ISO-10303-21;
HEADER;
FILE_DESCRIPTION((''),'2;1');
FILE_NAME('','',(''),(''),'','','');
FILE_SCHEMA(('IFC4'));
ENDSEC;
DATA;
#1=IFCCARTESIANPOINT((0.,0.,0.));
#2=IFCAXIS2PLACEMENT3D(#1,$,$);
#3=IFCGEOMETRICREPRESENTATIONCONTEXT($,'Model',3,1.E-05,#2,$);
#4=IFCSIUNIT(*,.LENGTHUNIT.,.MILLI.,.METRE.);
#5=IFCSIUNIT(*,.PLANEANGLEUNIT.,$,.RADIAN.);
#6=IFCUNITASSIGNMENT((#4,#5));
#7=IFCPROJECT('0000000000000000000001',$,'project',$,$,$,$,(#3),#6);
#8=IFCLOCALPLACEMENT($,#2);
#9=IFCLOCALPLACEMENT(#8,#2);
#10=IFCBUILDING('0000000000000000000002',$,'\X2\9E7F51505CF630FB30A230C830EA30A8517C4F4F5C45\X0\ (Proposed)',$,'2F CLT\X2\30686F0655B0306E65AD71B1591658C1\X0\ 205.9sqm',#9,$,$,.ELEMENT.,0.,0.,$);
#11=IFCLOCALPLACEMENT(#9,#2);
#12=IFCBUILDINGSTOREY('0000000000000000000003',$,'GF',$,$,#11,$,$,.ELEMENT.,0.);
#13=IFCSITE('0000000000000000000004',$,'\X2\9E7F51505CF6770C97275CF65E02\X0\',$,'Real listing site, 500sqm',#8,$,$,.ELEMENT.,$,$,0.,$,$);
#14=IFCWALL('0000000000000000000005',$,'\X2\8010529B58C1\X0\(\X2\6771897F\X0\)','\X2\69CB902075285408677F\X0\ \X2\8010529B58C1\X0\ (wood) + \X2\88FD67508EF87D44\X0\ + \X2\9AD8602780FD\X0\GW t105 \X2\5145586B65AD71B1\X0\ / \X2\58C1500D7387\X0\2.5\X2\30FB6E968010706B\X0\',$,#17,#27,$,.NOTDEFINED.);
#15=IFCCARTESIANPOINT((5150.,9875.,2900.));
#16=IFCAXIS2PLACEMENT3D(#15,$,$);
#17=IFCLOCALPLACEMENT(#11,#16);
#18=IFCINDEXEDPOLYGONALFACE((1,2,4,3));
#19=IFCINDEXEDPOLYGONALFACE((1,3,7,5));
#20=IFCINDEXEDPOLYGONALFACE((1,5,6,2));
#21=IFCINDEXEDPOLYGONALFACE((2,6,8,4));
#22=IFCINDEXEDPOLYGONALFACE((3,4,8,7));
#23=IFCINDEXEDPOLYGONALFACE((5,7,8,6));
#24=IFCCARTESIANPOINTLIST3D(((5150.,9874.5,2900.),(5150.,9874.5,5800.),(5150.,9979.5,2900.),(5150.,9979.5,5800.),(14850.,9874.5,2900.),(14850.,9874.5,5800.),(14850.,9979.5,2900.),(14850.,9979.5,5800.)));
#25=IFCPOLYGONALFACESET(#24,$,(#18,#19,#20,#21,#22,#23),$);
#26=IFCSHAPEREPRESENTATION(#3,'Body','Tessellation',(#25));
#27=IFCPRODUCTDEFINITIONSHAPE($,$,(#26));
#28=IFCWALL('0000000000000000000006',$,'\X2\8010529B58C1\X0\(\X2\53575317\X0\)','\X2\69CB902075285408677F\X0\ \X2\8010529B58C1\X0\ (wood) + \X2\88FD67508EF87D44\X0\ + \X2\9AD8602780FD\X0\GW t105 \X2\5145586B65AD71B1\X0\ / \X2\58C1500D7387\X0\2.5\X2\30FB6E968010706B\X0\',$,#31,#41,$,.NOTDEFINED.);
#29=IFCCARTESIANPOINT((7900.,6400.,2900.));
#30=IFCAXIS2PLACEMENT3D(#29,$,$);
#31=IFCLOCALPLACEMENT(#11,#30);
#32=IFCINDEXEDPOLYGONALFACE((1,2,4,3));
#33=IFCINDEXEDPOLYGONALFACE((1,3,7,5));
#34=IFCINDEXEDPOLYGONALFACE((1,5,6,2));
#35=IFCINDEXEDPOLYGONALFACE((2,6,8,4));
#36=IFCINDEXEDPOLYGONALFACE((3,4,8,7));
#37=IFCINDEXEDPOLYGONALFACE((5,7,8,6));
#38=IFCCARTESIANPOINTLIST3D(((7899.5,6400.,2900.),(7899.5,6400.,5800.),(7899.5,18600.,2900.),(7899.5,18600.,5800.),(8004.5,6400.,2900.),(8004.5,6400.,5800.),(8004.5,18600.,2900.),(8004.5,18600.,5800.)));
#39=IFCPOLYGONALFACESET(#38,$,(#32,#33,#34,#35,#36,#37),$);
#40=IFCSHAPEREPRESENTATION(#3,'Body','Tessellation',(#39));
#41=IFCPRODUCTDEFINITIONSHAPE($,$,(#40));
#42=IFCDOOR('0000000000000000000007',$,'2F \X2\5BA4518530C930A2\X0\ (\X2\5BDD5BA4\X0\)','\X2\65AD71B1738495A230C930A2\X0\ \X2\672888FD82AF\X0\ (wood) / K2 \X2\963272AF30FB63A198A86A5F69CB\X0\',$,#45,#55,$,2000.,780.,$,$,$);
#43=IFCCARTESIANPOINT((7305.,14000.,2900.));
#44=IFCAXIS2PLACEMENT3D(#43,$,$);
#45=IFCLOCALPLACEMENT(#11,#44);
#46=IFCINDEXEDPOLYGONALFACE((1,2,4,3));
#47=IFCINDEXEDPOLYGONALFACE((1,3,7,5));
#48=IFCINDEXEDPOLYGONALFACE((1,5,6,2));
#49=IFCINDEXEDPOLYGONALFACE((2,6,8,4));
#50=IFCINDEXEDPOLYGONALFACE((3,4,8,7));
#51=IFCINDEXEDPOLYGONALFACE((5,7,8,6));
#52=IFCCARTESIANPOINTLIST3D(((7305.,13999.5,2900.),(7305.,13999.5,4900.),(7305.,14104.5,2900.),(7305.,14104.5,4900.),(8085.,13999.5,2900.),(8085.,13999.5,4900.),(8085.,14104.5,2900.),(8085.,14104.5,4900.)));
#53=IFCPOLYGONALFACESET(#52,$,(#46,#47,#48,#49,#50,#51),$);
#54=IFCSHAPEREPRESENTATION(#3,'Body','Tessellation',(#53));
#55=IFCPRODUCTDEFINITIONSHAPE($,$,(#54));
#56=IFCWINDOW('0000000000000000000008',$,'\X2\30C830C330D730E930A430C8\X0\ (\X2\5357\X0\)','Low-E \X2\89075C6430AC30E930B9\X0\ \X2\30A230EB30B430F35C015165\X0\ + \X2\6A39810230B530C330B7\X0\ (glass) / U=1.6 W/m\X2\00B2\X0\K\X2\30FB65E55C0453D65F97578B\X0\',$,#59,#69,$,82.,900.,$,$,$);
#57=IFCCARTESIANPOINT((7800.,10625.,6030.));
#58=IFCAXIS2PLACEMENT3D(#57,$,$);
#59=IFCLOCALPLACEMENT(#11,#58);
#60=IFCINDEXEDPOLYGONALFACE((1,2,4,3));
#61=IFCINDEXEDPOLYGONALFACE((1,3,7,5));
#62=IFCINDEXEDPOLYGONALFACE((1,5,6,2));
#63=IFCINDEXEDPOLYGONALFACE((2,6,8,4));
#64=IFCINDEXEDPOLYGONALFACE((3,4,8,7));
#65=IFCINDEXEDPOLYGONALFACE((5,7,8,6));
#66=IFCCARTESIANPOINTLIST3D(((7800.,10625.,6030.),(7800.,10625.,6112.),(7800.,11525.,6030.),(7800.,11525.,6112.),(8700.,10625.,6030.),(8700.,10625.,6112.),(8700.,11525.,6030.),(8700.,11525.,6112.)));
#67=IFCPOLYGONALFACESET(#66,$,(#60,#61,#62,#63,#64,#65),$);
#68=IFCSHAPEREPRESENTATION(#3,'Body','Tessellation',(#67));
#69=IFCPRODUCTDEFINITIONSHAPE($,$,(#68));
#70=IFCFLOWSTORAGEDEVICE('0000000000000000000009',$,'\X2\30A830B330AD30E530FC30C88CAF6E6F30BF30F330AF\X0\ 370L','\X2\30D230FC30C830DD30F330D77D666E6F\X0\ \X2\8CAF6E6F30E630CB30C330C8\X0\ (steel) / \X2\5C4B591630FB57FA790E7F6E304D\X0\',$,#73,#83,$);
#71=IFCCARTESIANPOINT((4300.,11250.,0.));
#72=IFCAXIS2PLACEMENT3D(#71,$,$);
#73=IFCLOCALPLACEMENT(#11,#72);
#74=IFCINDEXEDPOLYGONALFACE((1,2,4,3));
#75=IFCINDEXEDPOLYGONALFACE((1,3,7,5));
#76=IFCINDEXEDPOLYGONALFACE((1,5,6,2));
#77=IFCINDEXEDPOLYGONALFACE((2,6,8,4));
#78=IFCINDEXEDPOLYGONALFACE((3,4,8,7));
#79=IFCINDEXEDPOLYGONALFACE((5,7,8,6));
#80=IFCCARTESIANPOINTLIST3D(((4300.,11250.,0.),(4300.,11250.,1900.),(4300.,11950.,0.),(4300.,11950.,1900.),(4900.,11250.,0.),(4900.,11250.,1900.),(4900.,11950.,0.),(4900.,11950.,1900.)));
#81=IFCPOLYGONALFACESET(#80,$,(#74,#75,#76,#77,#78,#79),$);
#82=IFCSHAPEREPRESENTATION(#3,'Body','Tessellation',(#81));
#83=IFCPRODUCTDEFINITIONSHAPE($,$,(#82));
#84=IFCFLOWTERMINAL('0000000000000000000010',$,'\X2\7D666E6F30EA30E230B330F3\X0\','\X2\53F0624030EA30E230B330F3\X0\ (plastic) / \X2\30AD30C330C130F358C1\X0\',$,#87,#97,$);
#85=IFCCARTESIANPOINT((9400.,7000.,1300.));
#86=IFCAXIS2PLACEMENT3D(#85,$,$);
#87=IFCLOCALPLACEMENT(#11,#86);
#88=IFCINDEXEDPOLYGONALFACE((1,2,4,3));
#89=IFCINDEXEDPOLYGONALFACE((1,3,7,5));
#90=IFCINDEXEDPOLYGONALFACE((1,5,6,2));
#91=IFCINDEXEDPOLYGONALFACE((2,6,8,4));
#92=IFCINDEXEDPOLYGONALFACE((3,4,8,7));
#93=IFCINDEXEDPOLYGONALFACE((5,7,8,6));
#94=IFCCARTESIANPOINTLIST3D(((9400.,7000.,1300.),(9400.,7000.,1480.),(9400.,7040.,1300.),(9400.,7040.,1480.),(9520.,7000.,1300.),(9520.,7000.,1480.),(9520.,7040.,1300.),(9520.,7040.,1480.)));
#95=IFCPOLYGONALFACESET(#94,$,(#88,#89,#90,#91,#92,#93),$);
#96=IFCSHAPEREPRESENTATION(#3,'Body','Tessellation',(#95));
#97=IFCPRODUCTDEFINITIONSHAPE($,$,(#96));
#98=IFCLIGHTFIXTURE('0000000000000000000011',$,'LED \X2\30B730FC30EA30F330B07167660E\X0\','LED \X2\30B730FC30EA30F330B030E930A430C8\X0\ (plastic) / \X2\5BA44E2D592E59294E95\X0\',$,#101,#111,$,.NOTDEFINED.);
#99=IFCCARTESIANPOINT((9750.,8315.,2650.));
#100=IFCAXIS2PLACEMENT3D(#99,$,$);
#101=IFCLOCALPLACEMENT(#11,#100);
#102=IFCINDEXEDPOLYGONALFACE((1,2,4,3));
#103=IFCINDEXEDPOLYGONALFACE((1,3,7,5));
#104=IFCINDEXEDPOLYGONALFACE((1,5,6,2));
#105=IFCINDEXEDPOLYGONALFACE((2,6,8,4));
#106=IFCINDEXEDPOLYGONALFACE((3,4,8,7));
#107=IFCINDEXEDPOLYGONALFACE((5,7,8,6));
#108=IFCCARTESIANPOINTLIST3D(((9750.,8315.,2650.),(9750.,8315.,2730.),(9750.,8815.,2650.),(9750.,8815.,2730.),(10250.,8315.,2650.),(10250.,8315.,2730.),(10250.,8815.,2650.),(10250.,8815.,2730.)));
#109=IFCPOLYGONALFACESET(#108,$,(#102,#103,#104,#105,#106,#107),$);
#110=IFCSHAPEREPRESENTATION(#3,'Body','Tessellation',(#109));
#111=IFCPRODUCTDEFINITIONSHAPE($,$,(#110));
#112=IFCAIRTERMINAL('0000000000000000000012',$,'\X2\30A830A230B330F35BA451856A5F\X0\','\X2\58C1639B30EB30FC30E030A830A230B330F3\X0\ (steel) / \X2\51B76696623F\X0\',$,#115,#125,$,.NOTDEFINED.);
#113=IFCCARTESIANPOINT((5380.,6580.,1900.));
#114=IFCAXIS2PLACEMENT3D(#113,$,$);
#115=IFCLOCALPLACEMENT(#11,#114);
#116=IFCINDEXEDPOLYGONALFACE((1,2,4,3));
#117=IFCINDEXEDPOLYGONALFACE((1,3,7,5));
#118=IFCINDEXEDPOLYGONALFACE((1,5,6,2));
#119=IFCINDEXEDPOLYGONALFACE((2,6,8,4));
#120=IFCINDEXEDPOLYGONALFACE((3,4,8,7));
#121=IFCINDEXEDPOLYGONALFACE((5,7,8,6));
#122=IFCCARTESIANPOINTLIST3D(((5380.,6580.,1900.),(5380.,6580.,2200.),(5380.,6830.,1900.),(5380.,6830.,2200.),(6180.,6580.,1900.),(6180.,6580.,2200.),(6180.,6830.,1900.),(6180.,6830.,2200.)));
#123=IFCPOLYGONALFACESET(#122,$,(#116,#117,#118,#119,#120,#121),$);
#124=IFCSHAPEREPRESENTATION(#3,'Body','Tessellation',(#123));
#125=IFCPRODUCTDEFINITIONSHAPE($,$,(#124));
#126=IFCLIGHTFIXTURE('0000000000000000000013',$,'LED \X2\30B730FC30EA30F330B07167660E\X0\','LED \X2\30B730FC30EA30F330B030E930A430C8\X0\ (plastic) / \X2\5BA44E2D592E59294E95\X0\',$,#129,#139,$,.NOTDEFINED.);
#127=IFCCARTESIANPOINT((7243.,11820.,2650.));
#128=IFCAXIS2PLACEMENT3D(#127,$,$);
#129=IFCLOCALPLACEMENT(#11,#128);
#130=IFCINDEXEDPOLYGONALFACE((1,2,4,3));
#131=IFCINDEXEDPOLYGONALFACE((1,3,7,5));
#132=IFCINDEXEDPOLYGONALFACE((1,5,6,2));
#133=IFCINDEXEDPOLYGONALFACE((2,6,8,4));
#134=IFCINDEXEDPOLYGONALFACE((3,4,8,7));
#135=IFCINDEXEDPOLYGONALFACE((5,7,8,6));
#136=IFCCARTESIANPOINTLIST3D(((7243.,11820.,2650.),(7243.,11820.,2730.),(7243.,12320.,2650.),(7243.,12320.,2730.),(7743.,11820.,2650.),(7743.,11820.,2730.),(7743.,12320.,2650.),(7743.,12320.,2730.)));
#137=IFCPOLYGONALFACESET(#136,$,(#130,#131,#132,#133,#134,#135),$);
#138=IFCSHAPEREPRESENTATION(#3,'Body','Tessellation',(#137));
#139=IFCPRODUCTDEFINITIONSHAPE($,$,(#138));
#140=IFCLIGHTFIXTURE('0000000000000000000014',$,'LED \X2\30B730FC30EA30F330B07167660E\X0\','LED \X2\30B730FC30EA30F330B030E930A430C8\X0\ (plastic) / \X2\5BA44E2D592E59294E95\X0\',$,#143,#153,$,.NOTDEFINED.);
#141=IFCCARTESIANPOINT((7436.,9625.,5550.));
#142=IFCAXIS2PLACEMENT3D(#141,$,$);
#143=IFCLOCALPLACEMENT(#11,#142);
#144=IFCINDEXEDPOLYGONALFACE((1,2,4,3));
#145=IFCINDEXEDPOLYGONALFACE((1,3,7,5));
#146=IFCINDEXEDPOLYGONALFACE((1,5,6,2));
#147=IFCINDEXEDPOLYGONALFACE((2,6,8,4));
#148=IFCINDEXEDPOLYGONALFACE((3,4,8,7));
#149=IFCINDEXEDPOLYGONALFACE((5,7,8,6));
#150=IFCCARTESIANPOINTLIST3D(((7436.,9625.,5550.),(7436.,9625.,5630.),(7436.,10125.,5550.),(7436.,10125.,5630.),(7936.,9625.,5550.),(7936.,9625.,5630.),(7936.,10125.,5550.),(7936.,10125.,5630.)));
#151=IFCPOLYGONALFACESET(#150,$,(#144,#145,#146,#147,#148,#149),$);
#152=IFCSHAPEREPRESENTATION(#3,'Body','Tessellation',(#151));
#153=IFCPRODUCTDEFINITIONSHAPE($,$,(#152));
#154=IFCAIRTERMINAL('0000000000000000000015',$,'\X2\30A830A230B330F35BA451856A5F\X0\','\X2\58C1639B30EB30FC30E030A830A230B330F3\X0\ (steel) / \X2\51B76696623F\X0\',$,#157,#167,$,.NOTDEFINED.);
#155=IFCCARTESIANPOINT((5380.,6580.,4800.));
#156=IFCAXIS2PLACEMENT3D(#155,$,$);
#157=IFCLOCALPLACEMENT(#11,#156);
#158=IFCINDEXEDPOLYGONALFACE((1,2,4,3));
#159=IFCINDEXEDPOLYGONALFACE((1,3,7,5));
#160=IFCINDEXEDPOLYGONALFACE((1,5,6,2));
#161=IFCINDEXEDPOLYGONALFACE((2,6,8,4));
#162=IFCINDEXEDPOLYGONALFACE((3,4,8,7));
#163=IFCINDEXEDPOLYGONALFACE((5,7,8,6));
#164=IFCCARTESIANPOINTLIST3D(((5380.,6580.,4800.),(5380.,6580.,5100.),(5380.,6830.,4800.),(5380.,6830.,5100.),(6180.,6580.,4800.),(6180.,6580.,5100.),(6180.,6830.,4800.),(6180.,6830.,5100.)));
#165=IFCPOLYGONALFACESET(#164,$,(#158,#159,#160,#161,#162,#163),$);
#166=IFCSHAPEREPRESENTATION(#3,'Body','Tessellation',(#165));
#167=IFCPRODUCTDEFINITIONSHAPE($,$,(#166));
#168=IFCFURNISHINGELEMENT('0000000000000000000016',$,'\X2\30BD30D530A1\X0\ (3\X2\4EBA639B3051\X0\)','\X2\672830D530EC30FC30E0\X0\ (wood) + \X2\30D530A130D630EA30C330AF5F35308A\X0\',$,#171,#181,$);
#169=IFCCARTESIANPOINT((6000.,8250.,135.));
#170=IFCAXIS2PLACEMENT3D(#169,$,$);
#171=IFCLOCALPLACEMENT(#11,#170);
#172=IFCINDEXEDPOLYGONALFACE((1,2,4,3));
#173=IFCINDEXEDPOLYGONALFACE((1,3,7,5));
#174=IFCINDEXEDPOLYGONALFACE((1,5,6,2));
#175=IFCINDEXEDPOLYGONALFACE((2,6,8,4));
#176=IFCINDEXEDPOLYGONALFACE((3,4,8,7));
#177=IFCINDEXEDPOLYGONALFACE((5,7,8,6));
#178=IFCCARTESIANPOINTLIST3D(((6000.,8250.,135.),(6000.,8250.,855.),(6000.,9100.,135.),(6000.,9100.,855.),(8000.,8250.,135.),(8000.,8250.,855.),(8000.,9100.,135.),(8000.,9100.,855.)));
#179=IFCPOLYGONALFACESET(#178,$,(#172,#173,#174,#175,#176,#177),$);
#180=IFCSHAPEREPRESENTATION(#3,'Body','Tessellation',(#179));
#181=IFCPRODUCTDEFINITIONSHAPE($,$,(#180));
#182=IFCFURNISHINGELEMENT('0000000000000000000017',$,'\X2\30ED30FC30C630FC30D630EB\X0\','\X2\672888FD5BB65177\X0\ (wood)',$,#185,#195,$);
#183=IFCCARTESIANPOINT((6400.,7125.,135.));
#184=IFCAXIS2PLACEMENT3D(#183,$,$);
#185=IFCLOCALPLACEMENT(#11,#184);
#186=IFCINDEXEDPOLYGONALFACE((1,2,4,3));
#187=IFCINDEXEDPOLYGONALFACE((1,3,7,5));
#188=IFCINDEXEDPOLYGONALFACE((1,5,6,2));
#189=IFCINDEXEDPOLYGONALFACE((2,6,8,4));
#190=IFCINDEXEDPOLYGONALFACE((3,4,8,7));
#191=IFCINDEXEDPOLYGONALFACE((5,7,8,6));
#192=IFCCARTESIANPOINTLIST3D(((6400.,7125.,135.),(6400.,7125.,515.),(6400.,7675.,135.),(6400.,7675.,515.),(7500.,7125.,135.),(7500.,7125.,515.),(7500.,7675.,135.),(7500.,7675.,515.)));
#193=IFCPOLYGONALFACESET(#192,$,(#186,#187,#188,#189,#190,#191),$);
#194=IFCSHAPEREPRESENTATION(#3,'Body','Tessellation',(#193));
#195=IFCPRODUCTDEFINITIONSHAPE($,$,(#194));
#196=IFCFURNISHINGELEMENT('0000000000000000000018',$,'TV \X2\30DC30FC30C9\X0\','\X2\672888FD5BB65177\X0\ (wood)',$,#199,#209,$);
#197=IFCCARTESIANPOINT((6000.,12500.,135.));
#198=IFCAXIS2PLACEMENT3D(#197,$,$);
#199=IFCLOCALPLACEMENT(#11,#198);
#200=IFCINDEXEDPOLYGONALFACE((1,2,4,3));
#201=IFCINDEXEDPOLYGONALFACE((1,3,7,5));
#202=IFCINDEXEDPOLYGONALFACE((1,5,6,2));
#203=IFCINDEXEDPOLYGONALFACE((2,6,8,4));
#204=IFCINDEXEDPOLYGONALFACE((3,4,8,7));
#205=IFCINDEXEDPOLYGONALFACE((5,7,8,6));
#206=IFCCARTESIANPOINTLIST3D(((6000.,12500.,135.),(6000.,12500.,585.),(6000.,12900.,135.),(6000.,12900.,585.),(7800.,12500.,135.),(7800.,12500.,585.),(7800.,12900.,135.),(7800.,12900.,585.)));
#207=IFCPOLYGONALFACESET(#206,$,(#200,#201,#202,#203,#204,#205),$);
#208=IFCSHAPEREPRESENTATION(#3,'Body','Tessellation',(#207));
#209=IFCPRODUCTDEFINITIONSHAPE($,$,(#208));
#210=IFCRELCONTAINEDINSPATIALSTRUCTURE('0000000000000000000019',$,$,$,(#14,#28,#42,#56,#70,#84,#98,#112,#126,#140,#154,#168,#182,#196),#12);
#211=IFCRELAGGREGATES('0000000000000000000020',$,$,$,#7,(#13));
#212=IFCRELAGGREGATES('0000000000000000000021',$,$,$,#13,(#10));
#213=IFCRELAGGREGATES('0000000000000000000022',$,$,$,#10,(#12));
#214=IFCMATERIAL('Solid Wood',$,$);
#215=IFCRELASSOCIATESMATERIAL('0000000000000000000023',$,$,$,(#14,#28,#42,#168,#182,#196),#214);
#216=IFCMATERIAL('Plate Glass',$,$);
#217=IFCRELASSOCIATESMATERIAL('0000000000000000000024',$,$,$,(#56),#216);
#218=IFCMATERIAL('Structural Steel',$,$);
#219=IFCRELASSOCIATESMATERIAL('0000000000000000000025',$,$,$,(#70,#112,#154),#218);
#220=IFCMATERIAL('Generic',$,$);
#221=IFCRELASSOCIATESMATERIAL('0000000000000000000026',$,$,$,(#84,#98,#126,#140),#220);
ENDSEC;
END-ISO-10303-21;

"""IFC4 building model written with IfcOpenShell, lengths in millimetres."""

from ifc_helpers import new_model, si_unit, frame, frame_2d, origin, place, context, project, spatial, rectangle, extrude, material, element, fill, save


model = new_model("IFC4")

# Units and contexts
model_context = context("Model", 3, precision=1e-05, world=origin())
ifc_project = project(units=[si_unit("LENGTHUNIT", "METRE", prefix="MILLI"), si_unit("PLANEANGLEUNIT", "RADIAN")], contexts=[model_context])

# Site, building, storey
site_placement = place(None, origin())
site = spatial("IfcSite", under=ifc_project, at=site_placement, Name="鹿児島県霧島市", ObjectType="Real listing site, 500sqm", CompositionType="ELEMENT", RefElevation=0.0)
building_placement = place(site_placement, origin())
building = spatial("IfcBuilding", under=site, at=building_placement, Name="鹿児島・アトリエ兼住居 (Proposed)", ObjectType="2F CLTと漆喰の断熱外壁 205.9sqm", CompositionType="ELEMENT", ElevationOfRefHeight=0.0, ElevationOfTerrain=0.0)
storey_placement = place(building_placement, origin())
storey = spatial("IfcBuildingStorey", under=building, at=storey_placement, Name="GF", CompositionType="ELEMENT", Elevation=0.0)

# Shared definitions
ifc_material_1 = material(Name="Solid Wood")

# Wall
wall_1_placement = place(storey_placement, frame((5150.0, 9875.0, 2900.0)))
element("IfcWall", 1, at=wall_1_placement, inside=storey, material=ifc_material_1, Name="耐力壁(東西)", Description="構造用合板 耐力壁 (wood) + 製材軸組 + 高性能GW t105 充填断熱 / 壁倍率2.5・準耐火", PredefinedType="NOTDEFINED", context=model_context, shape_type="SweptSolid", body=[
    extrude(rectangle(XDim=9700.0, YDim=105.0, at=frame_2d((4850.0, 52.0))), frame((5150.0, 9875.0, 2900.0)), (0.0, 0.0, 1.0), 2900.0),
])

# Wall, opening, door
wall_2_placement = place(storey_placement, frame((7900.0, 6400.0, 2900.0)))
wall_2 = element("IfcWall", 2, at=wall_2_placement, inside=storey, material=ifc_material_1, Name="耐力壁(南北)", Description="構造用合板 耐力壁 (wood) + 製材軸組 + 高性能GW t105 充填断熱 / 壁倍率2.5・準耐火", PredefinedType="NOTDEFINED", context=model_context, shape_type="SweptSolid", body=[
    extrude(rectangle(XDim=105.0, YDim=12200.0, at=frame_2d((52.0, 6100.0))), frame((7900.0, 6400.0, 2900.0)), (0.0, 0.0, 1.0), 2900.0),
])
opening_placement = place(storey_placement, frame((7305.0, 14000.0, 2900.0)))
opening = element("IfcOpeningElement", 3, at=opening_placement, cuts=wall_2, PredefinedType="NOTDEFINED", context=model_context, shape_type="SweptSolid", body=[
    extrude(rectangle(XDim=780.0, YDim=105.0, at=frame_2d((390.0, 52.0))), frame((7305.0, 14000.0, 2900.0)), (0.0, 0.0, 1.0), 2000.0),
])
door_placement = place(storey_placement, frame((7305.0, 14000.0, 2900.0)))
door = element("IfcDoor", 4, at=door_placement, inside=storey, material=ifc_material_1, Name="2F 室内ドア (寝室)", Description="断熱玄関ドア 木製芯 (wood) / K2 防犯・採風機構", OverallHeight=2000.0, OverallWidth=780.0, context=model_context, shape_type="SweptSolid", body=[
    extrude(rectangle(XDim=780.0, YDim=105.0, at=frame_2d((390.0, 52.0))), frame((7305.0, 14000.0, 2900.0)), (0.0, 0.0, 1.0), 2000.0),
])
fill(opening, door)

# Window
ifc_material_2 = material(Name="Plate Glass")
window_placement = place(storey_placement, frame((7800.0, 10625.0, 6030.0)))
element("IfcWindow", 5, at=window_placement, inside=storey, material=ifc_material_2, Name="トップライト (南)", Description="Low-E 複層ガラス アルゴン封入 + 樹脂サッシ (glass) / U=1.6 W/m²K・日射取得型", OverallHeight=82.0, OverallWidth=900.0, context=model_context, shape_type="SweptSolid", body=[
    extrude(rectangle(XDim=900.0, YDim=900.0, at=frame_2d((450.0, 450.0))), frame((7800.0, 10625.0, 6030.0)), (0.0, 0.0, 1.0), 82.0),
])

# Flow storage device
ifc_material_3 = material(Name="Structural Steel")
flow_storage_device_placement = place(storey_placement, frame((4300.0, 11250.0, 0.0)))
element("IfcFlowStorageDevice", 6, at=flow_storage_device_placement, inside=storey, material=ifc_material_3, Name="エコキュート貯湯タンク 370L", Description="ヒートポンプ給湯 貯湯ユニット (steel) / 屋外・基礎置き", context=model_context, shape_type="SweptSolid", body=[
    extrude(rectangle(XDim=600.0, YDim=700.0, at=frame_2d((300.0, 350.0))), frame((4300.0, 11250.0, 0.0)), (0.0, 0.0, 1.0), 1900.0),
])

# Flow terminal
ifc_material_4 = material(Name="Generic")
flow_terminal_placement = place(storey_placement, frame((9400.0, 7000.0, 1300.0)))
element("IfcFlowTerminal", 7, at=flow_terminal_placement, inside=storey, material=ifc_material_4, Name="給湯リモコン", Description="台所リモコン (plastic) / キッチン壁", context=model_context, shape_type="SweptSolid", body=[
    extrude(rectangle(XDim=120.0, YDim=40.0, at=frame_2d((60.0, 20.0))), frame((9400.0, 7000.0, 1300.0)), (0.0, 0.0, 1.0), 180.0),
])

# Light fixture
light_fixture_1_placement = place(storey_placement, frame((9750.0, 8315.0, 2650.0)))
element("IfcLightFixture", 8, at=light_fixture_1_placement, inside=storey, material=ifc_material_4, Name="LED シーリング照明", Description="LED シーリングライト (plastic) / 室中央天井", PredefinedType="NOTDEFINED", context=model_context, shape_type="SweptSolid", body=[
    extrude(rectangle(XDim=500.0, YDim=500.0, at=frame_2d((250.0, 250.0))), frame((9750.0, 8315.0, 2650.0)), (0.0, 0.0, 1.0), 80.0),
])

# Air terminal
air_terminal_1_placement = place(storey_placement, frame((5380.0, 6580.0, 1900.0)))
element("IfcAirTerminal", 9, at=air_terminal_1_placement, inside=storey, material=ifc_material_3, Name="エアコン室内機", Description="壁掛ルームエアコン (steel) / 冷暖房", PredefinedType="NOTDEFINED", context=model_context, shape_type="SweptSolid", body=[
    extrude(rectangle(XDim=800.0, YDim=250.0, at=frame_2d((400.0, 125.0))), frame((5380.0, 6580.0, 1900.0)), (0.0, 0.0, 1.0), 300.0),
])

# Light fixtures
light_fixture_2_placement = place(storey_placement, frame((7243.0, 11820.0, 2650.0)))
element("IfcLightFixture", 10, at=light_fixture_2_placement, inside=storey, material=ifc_material_4, Name="LED シーリング照明", Description="LED シーリングライト (plastic) / 室中央天井", PredefinedType="NOTDEFINED", context=model_context, shape_type="SweptSolid", body=[
    extrude(rectangle(XDim=500.0, YDim=500.0, at=frame_2d((250.0, 250.0))), frame((7243.0, 11820.0, 2650.0)), (0.0, 0.0, 1.0), 80.0),
])
light_fixture_3_placement = place(storey_placement, frame((7436.0, 9625.0, 5550.0)))
element("IfcLightFixture", 11, at=light_fixture_3_placement, inside=storey, material=ifc_material_4, Name="LED シーリング照明", Description="LED シーリングライト (plastic) / 室中央天井", PredefinedType="NOTDEFINED", context=model_context, shape_type="SweptSolid", body=[
    extrude(rectangle(XDim=500.0, YDim=500.0, at=frame_2d((250.0, 250.0))), frame((7436.0, 9625.0, 5550.0)), (0.0, 0.0, 1.0), 80.0),
])

# Air terminal
air_terminal_2_placement = place(storey_placement, frame((5380.0, 6580.0, 4800.0)))
element("IfcAirTerminal", 12, at=air_terminal_2_placement, inside=storey, material=ifc_material_3, Name="エアコン室内機", Description="壁掛ルームエアコン (steel) / 冷暖房", PredefinedType="NOTDEFINED", context=model_context, shape_type="SweptSolid", body=[
    extrude(rectangle(XDim=800.0, YDim=250.0, at=frame_2d((400.0, 125.0))), frame((5380.0, 6580.0, 4800.0)), (0.0, 0.0, 1.0), 300.0),
])

# Furnishing elements
furnishing_1_placement = place(storey_placement, frame((6000.0, 8250.0, 135.0)))
element("IfcFurnishingElement", 13, at=furnishing_1_placement, inside=storey, material=ifc_material_1, Name="ソファ (3人掛け)", Description="木フレーム (wood) + ファブリック張り", context=model_context, shape_type="SweptSolid", body=[
    extrude(rectangle(XDim=2000.0, YDim=850.0, at=frame_2d((1000.0, 425.0))), frame((6000.0, 8250.0, 135.0)), (0.0, 0.0, 1.0), 720.0),
])
furnishing_2_placement = place(storey_placement, frame((6400.0, 7125.0, 135.0)))
element("IfcFurnishingElement", 14, at=furnishing_2_placement, inside=storey, material=ifc_material_1, Name="ローテーブル", Description="木製家具 (wood)", context=model_context, shape_type="SweptSolid", body=[
    extrude(rectangle(XDim=1100.0, YDim=550.0, at=frame_2d((550.0, 275.0))), frame((6400.0, 7125.0, 135.0)), (0.0, 0.0, 1.0), 380.0),
])
furnishing_3_placement = place(storey_placement, frame((6000.0, 12500.0, 135.0)))
element("IfcFurnishingElement", 15, at=furnishing_3_placement, inside=storey, material=ifc_material_1, Name="TV ボード", Description="木製家具 (wood)", context=model_context, shape_type="SweptSolid", body=[
    extrude(rectangle(XDim=1800.0, YDim=400.0, at=frame_2d((900.0, 200.0))), frame((6000.0, 12500.0, 135.0)), (0.0, 0.0, 1.0), 450.0),
])

save(model, "model.ifc")
